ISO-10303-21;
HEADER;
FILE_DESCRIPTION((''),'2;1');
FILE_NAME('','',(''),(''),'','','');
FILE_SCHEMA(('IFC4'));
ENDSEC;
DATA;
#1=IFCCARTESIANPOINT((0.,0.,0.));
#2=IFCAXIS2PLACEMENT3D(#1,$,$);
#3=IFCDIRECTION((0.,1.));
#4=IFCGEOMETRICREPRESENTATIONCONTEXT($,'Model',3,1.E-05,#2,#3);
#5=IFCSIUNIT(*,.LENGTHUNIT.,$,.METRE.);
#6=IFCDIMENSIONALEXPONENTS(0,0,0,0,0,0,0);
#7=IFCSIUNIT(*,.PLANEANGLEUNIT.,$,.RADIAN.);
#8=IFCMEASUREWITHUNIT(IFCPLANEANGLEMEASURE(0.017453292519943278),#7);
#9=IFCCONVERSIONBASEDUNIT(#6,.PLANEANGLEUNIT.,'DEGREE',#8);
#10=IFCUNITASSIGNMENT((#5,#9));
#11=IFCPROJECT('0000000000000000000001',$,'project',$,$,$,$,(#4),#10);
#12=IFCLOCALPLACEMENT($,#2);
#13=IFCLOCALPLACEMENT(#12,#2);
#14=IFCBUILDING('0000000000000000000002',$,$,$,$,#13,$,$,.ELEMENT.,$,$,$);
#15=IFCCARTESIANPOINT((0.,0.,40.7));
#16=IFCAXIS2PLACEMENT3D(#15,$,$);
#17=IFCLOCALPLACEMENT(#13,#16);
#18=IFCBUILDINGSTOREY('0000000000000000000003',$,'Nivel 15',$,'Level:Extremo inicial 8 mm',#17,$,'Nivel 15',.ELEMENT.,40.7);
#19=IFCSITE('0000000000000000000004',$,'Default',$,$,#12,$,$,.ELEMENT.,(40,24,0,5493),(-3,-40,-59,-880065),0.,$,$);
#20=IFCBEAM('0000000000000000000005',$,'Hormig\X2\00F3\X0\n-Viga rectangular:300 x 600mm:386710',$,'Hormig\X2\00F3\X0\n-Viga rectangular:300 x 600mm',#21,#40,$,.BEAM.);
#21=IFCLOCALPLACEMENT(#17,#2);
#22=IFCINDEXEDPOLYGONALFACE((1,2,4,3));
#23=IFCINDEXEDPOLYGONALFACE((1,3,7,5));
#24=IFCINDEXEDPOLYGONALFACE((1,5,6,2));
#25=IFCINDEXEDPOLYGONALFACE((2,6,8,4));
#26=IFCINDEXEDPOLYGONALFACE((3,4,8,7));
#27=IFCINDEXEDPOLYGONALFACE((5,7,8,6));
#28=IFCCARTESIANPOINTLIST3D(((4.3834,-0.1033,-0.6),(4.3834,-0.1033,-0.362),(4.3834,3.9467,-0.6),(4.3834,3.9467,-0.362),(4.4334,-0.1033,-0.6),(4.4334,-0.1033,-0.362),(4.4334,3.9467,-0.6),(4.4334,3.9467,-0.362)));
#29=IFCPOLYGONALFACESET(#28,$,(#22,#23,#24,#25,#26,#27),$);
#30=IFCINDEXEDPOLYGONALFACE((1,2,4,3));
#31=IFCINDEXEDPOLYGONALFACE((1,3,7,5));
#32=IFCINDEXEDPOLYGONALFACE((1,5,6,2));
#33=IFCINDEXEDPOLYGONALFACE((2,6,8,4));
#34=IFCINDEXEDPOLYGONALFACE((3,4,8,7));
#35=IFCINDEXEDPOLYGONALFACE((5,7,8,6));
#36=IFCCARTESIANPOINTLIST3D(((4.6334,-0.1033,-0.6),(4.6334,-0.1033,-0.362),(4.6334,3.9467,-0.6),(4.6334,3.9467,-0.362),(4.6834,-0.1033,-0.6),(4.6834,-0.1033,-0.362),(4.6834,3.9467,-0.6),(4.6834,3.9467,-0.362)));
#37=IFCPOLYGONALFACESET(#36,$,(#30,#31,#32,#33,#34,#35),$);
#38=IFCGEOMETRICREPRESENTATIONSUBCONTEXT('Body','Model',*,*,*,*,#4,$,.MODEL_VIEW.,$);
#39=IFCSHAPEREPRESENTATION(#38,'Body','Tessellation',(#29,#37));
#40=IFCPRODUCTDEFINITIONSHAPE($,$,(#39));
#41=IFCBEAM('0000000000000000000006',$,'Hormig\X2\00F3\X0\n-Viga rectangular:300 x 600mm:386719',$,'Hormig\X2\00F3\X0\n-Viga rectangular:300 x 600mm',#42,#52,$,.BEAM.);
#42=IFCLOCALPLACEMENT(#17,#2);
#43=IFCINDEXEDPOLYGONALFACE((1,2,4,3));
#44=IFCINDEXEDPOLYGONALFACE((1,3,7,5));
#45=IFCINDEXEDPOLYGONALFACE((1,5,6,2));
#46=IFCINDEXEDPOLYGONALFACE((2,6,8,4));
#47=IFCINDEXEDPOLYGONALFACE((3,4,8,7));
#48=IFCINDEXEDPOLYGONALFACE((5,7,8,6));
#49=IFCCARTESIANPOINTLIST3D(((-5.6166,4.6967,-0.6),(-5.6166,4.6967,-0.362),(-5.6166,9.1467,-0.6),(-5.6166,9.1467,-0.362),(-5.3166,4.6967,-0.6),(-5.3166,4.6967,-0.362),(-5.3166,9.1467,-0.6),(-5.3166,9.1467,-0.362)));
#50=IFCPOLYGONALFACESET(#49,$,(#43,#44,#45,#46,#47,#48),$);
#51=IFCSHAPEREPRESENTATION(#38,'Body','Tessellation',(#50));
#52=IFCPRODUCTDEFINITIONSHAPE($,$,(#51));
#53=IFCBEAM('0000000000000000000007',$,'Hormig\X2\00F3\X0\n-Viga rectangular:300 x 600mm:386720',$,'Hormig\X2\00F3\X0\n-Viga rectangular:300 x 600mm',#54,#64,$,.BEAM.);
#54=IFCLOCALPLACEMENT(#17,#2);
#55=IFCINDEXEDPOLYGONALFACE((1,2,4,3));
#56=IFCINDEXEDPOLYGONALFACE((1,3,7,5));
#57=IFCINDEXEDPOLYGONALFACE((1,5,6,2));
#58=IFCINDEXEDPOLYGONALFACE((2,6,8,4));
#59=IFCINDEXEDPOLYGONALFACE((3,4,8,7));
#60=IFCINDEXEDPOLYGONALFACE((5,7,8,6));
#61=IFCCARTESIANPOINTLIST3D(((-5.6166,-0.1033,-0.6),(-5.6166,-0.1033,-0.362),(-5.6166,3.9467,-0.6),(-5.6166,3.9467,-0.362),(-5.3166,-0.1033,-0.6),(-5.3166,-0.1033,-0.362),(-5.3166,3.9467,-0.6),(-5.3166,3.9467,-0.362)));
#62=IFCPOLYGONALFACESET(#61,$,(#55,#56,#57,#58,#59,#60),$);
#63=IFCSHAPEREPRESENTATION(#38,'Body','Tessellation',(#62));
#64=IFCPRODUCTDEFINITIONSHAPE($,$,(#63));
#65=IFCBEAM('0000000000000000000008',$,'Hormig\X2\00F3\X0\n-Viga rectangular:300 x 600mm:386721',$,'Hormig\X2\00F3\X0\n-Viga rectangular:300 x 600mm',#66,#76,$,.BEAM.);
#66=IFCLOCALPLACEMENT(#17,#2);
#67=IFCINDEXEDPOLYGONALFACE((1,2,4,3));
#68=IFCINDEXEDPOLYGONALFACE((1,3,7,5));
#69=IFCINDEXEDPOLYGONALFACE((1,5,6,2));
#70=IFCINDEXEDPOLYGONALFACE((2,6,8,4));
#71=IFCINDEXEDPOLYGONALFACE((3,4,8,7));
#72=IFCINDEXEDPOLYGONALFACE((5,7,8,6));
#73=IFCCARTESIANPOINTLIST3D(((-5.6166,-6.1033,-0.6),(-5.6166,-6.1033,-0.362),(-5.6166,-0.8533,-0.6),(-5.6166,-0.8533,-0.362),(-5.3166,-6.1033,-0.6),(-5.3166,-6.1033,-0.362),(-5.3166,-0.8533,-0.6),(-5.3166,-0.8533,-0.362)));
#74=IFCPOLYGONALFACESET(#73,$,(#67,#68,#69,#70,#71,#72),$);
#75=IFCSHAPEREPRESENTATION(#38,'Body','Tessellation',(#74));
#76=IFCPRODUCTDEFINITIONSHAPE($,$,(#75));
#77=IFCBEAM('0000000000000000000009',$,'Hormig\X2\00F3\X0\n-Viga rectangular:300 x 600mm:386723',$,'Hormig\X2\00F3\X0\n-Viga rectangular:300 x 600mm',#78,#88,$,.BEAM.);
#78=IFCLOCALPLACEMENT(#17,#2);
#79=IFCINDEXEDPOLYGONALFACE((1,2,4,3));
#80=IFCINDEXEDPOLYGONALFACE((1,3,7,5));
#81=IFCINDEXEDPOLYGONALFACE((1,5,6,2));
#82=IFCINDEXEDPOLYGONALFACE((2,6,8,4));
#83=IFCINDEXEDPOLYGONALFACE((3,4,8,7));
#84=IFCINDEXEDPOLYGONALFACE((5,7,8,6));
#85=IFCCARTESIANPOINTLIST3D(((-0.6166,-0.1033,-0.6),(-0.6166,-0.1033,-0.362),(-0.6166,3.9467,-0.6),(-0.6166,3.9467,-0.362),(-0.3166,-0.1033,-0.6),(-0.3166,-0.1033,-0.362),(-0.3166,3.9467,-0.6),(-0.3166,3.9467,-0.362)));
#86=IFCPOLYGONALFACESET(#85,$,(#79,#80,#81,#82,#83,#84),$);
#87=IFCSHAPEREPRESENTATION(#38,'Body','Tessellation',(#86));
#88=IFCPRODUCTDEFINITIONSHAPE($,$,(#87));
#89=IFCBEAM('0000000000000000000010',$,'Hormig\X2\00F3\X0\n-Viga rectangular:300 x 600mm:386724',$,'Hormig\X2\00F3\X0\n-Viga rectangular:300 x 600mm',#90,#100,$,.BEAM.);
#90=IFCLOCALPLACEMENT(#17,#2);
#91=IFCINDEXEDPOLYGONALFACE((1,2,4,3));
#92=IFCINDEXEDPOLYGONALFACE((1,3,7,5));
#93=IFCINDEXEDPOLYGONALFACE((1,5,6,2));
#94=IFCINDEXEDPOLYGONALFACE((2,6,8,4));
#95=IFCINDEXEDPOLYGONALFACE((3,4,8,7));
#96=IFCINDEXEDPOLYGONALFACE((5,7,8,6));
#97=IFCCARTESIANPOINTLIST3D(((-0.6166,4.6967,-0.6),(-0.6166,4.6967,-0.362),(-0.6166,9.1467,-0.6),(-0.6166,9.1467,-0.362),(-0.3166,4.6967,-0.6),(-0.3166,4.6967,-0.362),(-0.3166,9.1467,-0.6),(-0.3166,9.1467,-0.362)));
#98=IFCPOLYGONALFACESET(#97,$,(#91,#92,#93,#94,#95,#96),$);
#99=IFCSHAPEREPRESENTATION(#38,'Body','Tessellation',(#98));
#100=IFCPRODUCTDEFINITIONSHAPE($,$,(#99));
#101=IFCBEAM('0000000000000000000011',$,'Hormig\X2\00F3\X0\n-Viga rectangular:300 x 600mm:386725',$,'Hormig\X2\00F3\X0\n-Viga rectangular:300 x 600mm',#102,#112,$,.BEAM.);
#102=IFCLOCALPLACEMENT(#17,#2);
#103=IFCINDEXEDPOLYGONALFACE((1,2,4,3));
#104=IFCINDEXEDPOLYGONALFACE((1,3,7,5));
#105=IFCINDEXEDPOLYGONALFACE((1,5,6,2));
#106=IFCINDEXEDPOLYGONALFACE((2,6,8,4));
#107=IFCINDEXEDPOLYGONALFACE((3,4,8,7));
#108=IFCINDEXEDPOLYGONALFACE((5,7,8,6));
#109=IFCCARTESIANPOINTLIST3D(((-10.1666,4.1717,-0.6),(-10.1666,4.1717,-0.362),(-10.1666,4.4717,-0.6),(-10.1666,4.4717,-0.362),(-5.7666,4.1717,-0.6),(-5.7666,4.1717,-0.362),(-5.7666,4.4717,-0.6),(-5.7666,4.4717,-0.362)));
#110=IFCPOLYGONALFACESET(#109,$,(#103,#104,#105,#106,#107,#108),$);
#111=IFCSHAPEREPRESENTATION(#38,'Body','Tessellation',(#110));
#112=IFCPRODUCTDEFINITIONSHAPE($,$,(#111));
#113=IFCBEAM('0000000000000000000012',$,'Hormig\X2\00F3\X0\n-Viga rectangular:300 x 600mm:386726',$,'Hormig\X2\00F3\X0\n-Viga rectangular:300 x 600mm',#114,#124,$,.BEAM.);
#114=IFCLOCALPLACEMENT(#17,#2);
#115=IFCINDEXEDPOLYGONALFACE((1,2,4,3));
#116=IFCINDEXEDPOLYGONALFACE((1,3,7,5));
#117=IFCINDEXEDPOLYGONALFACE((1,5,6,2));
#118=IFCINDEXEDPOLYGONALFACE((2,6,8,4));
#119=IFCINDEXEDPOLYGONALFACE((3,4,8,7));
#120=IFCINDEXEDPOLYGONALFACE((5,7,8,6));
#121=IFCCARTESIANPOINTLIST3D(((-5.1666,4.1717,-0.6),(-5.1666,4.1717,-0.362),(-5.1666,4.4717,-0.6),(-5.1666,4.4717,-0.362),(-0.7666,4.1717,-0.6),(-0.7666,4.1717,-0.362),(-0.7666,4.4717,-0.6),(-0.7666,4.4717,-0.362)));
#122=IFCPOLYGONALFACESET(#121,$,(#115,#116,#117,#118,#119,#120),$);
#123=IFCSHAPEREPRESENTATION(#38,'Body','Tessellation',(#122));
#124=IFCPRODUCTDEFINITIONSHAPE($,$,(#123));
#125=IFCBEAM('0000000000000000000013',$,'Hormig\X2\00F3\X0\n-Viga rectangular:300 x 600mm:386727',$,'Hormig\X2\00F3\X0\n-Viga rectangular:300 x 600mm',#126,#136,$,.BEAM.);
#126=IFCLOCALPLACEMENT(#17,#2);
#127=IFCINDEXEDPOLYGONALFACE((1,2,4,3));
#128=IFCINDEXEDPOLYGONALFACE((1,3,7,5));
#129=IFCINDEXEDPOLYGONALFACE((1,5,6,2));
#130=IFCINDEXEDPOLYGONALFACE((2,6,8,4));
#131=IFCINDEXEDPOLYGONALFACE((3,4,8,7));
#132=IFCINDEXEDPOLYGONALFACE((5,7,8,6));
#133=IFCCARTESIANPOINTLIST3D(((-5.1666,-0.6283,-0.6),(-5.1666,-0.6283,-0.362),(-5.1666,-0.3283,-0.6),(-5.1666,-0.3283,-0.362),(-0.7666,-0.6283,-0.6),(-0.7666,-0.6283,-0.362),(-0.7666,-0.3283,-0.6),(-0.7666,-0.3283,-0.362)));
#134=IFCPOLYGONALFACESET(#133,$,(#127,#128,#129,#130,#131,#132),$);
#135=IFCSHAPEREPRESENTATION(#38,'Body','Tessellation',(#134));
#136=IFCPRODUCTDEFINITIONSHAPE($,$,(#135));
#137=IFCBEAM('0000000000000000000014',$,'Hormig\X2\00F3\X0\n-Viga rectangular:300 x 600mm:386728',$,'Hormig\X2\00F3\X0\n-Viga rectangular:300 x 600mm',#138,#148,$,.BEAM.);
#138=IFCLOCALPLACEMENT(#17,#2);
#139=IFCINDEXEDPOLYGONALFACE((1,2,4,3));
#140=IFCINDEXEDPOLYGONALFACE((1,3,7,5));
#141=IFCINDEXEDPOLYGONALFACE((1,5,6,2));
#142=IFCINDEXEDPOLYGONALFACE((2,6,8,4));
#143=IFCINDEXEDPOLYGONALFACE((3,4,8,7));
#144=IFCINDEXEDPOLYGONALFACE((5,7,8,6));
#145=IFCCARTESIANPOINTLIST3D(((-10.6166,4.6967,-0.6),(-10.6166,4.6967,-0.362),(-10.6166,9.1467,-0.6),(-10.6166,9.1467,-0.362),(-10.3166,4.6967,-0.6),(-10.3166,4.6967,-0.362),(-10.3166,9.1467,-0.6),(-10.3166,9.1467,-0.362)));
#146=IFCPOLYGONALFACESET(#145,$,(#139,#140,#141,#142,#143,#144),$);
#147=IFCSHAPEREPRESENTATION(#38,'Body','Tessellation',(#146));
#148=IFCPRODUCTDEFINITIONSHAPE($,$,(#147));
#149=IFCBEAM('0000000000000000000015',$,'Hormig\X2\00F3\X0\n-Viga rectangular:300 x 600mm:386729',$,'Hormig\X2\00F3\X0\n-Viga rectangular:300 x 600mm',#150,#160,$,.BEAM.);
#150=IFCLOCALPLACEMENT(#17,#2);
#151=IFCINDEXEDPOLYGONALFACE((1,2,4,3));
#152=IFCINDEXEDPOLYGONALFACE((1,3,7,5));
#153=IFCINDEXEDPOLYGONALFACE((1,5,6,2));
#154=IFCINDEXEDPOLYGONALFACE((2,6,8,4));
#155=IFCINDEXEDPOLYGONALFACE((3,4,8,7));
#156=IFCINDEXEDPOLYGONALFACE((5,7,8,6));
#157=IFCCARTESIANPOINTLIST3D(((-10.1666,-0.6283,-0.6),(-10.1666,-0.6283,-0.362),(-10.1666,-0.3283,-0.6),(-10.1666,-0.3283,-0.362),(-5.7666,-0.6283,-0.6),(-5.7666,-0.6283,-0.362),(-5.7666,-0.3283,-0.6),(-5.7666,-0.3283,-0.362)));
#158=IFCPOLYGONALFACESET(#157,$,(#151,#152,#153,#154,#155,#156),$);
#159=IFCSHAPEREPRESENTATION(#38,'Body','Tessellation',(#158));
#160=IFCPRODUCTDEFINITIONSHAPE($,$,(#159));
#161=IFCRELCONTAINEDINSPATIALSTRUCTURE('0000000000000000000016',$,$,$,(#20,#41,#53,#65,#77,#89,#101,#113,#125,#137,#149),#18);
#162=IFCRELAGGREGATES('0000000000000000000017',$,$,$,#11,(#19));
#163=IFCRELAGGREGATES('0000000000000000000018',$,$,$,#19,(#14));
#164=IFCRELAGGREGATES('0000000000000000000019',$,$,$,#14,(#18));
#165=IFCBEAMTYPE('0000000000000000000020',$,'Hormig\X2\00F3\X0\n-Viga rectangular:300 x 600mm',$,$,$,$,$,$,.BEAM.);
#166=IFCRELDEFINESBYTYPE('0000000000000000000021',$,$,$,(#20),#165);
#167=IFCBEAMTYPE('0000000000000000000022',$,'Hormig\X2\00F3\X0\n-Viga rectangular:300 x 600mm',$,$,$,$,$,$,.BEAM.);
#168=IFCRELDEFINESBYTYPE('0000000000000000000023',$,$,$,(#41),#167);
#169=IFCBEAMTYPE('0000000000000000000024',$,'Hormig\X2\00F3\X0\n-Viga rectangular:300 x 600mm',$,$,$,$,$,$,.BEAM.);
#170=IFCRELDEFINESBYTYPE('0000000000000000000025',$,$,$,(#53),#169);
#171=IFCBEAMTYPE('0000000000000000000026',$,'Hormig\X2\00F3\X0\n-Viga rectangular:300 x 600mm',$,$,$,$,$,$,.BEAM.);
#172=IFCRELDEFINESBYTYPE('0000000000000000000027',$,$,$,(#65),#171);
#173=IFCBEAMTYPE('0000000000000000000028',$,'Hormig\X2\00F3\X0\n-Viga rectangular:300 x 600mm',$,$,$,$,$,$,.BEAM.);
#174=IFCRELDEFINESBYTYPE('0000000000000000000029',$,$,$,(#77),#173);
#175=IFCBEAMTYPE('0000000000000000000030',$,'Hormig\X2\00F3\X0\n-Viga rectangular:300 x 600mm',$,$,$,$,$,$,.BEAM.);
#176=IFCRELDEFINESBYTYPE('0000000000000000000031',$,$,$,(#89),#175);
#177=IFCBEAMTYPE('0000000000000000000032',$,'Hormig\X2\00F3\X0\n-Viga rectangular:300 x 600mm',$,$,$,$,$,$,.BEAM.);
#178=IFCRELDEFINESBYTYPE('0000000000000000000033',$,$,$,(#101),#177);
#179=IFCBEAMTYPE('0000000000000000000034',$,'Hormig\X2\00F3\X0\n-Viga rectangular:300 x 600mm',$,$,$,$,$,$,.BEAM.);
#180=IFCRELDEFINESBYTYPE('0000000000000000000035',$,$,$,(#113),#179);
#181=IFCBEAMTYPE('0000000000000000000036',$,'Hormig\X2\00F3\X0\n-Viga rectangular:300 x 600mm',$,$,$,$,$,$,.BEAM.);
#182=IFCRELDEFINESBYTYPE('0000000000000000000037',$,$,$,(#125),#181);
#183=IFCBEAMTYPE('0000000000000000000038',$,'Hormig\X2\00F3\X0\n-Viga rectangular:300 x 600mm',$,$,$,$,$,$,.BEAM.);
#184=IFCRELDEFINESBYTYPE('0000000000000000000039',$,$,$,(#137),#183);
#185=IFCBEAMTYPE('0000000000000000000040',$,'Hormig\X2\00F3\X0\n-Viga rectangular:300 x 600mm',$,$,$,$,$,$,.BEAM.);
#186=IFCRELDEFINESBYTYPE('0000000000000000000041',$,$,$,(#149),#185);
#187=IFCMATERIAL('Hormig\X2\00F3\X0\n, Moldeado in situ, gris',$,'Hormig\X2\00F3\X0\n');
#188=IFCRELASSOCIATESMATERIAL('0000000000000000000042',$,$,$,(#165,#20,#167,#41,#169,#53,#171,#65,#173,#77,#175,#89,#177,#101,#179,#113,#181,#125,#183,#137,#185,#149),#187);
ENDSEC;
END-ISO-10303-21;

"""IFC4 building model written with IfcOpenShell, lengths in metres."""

from ifc_helpers import new_model, entity, si_unit, converted_unit, direction, frame, origin, place, context, subcontext, project, spatial, indexed_curve, outline, extrude, source, transform, mapped, material, type_object, type_shapes, element, save


model = new_model("IFC4")

# Units and contexts
model_context = context("Model", 3, precision=1e-05, world=origin(), true_north=direction((0.0, 1.0)))
body_context = subcontext(model_context, "Body", "Model", "MODEL_VIEW")
ifc_project = project(units=[si_unit("LENGTHUNIT", "METRE"), converted_unit("PLANEANGLEUNIT", "DEGREE", entity("IfcPlaneAngleMeasure", 0.017453292519943278), si_unit("PLANEANGLEUNIT", "RADIAN"), dimensions=[0, 0, 0, 0, 0, 0, 0])], contexts=[model_context])

# Site, building, storey
site_placement = place(None, origin())
site = spatial("IfcSite", under=ifc_project, at=site_placement, Name="Default", CompositionType="ELEMENT", RefLatitude=(40, 24, 0, 5493), RefLongitude=(-3, -40, -59, -880065), RefElevation=0.0)
building_placement = place(site_placement, origin())
building = spatial("IfcBuilding", under=site, at=building_placement, CompositionType="ELEMENT")
storey_placement = place(building_placement, frame((0.0, 0.0, 40.7)))
storey = spatial("IfcBuildingStorey", under=building, at=storey_placement, Name="Nivel 15", ObjectType="Level:Extremo inicial 8 mm", LongName="Nivel 15", CompositionType="ELEMENT", Elevation=40.7)

# Shared definitions
ifc_material_1 = material(Name="Hormigón, Moldeado in situ, gris", Category="Hormigón")

# Beams
beam_type_1 = type_object("IfcBeamType", Name="Hormigón-Viga rectangular:300 x 600mm", PredefinedType="BEAM", material=ifc_material_1)
shared_shape_1 = source(origin(), body_context, "Body", "SweptSolid", [
    extrude(outline(indexed_curve([(-0.025, -0.119), (0.025, -0.119), (0.025, 0.119), (-0.025, 0.119), (-0.025, -0.119)], self_intersect=False)), frame((4.4084, 3.9467, 40.219), z_axis=(0.0, -1.0, 0.0), x_axis=(-1.0, 0.0, 0.0)), (0.0, 0.0, 1.0), 4.05),
    extrude(outline(indexed_curve([(-0.025, -0.119), (0.025, -0.119), (0.025, 0.119), (-0.025, 0.119), (-0.025, -0.119)], self_intersect=False)), frame((4.6584, 3.9467, 40.219), z_axis=(0.0, -1.0, 0.0), x_axis=(-1.0, 0.0, 0.0)), (0.0, 0.0, 1.0), 4.05),
])
type_shapes(beam_type_1, [shared_shape_1])
beam_1_placement = place(storey_placement, frame((0.0, 0.0, -40.7)))
element("IfcBeam", 1, at=beam_1_placement, inside=storey, type_object=beam_type_1, material=ifc_material_1, Name="Hormigón-Viga rectangular:300 x 600mm:386710", ObjectType="Hormigón-Viga rectangular:300 x 600mm", PredefinedType="BEAM", context=body_context, shape_type="MappedRepresentation", body=[
    mapped(shared_shape_1, transform((0.0, 0.0, 0.0), scale=1.0)),
])
beam_type_2 = type_object("IfcBeamType", Name="Hormigón-Viga rectangular:300 x 600mm", PredefinedType="BEAM", material=ifc_material_1)
shared_shape_2 = source(origin(), body_context, "Body", "SweptSolid", [
    extrude(outline(indexed_curve([(-0.15, -0.119), (0.15, -0.119), (0.15, 0.119), (-0.15, 0.119), (-0.15, -0.119)], self_intersect=False)), frame((-5.4666, 9.1467, 40.219), z_axis=(0.0, -1.0, 0.0), x_axis=(-1.0, 0.0, 0.0)), (0.0, 0.0, 1.0), 4.45),
])
type_shapes(beam_type_2, [shared_shape_2])
beam_2_placement = place(storey_placement, frame((0.0, 0.0, -40.7)))
element("IfcBeam", 2, at=beam_2_placement, inside=storey, type_object=beam_type_2, material=ifc_material_1, Name="Hormigón-Viga rectangular:300 x 600mm:386719", ObjectType="Hormigón-Viga rectangular:300 x 600mm", PredefinedType="BEAM", context=body_context, shape_type="MappedRepresentation", body=[
    mapped(shared_shape_2, transform((0.0, 0.0, 0.0), scale=1.0)),
])
beam_type_3 = type_object("IfcBeamType", Name="Hormigón-Viga rectangular:300 x 600mm", PredefinedType="BEAM", material=ifc_material_1)
shared_shape_3 = source(origin(), body_context, "Body", "SweptSolid", [
    extrude(outline(indexed_curve([(-0.15, -0.119), (0.15, -0.119), (0.15, 0.119), (-0.15, 0.119), (-0.15, -0.119)], self_intersect=False)), frame((-5.4666, 3.9467, 40.219), z_axis=(0.0, -1.0, 0.0), x_axis=(-1.0, 0.0, 0.0)), (0.0, 0.0, 1.0), 4.05),
])
type_shapes(beam_type_3, [shared_shape_3])
beam_3_placement = place(storey_placement, frame((0.0, 0.0, -40.7)))
element("IfcBeam", 3, at=beam_3_placement, inside=storey, type_object=beam_type_3, material=ifc_material_1, Name="Hormigón-Viga rectangular:300 x 600mm:386720", ObjectType="Hormigón-Viga rectangular:300 x 600mm", PredefinedType="BEAM", context=body_context, shape_type="MappedRepresentation", body=[
    mapped(shared_shape_3, transform((0.0, 0.0, 0.0), scale=1.0)),
])
beam_type_4 = type_object("IfcBeamType", Name="Hormigón-Viga rectangular:300 x 600mm", PredefinedType="BEAM", material=ifc_material_1)
shared_shape_4 = source(origin(), body_context, "Body", "SweptSolid", [
    extrude(outline(indexed_curve([(-0.15, -0.119), (0.15, -0.119), (0.15, 0.119), (-0.15, 0.119), (-0.15, -0.119)], self_intersect=False)), frame((-5.4666, -6.1033, 40.219), z_axis=(0.0, 1.0, 0.0), x_axis=(-1.0, 0.0, 0.0)), (0.0, 0.0, 1.0), 5.25),
])
type_shapes(beam_type_4, [shared_shape_4])
beam_4_placement = place(storey_placement, frame((0.0, 0.0, -40.7)))
element("IfcBeam", 4, at=beam_4_placement, inside=storey, type_object=beam_type_4, material=ifc_material_1, Name="Hormigón-Viga rectangular:300 x 600mm:386721", ObjectType="Hormigón-Viga rectangular:300 x 600mm", PredefinedType="BEAM", context=body_context, shape_type="MappedRepresentation", body=[
    mapped(shared_shape_4, transform((0.0, 0.0, 0.0), scale=1.0)),
])
beam_type_5 = type_object("IfcBeamType", Name="Hormigón-Viga rectangular:300 x 600mm", PredefinedType="BEAM", material=ifc_material_1)
shared_shape_5 = source(origin(), body_context, "Body", "SweptSolid", [
    extrude(outline(indexed_curve([(-0.15, -0.119), (0.15, -0.119), (0.15, 0.119), (-0.15, 0.119), (-0.15, -0.119)], self_intersect=False)), frame((-0.4666, -0.1033, 40.219), z_axis=(0.0, 1.0, 0.0), x_axis=(-1.0, 0.0, 0.0)), (0.0, 0.0, 1.0), 4.05),
])
type_shapes(beam_type_5, [shared_shape_5])
beam_5_placement = place(storey_placement, frame((0.0, 0.0, -40.7)))
element("IfcBeam", 5, at=beam_5_placement, inside=storey, type_object=beam_type_5, material=ifc_material_1, Name="Hormigón-Viga rectangular:300 x 600mm:386723", ObjectType="Hormigón-Viga rectangular:300 x 600mm", PredefinedType="BEAM", context=body_context, shape_type="MappedRepresentation", body=[
    mapped(shared_shape_5, transform((0.0, 0.0, 0.0), scale=1.0)),
])
beam_type_6 = type_object("IfcBeamType", Name="Hormigón-Viga rectangular:300 x 600mm", PredefinedType="BEAM", material=ifc_material_1)
shared_shape_6 = source(origin(), body_context, "Body", "SweptSolid", [
    extrude(outline(indexed_curve([(-0.15, -0.119), (0.15, -0.119), (0.15, 0.119), (-0.15, 0.119), (-0.15, -0.119)], self_intersect=False)), frame((-0.4666, 9.1467, 40.219), z_axis=(0.0, -1.0, 0.0), x_axis=(-1.0, 0.0, 0.0)), (0.0, 0.0, 1.0), 4.45),
])
type_shapes(beam_type_6, [shared_shape_6])
beam_6_placement = place(storey_placement, frame((0.0, 0.0, -40.7)))
element("IfcBeam", 6, at=beam_6_placement, inside=storey, type_object=beam_type_6, material=ifc_material_1, Name="Hormigón-Viga rectangular:300 x 600mm:386724", ObjectType="Hormigón-Viga rectangular:300 x 600mm", PredefinedType="BEAM", context=body_context, shape_type="MappedRepresentation", body=[
    mapped(shared_shape_6, transform((0.0, 0.0, 0.0), scale=1.0)),
])
beam_type_7 = type_object("IfcBeamType", Name="Hormigón-Viga rectangular:300 x 600mm", PredefinedType="BEAM", material=ifc_material_1)
shared_shape_7 = source(origin(), body_context, "Body", "SweptSolid", [
    extrude(outline(indexed_curve([(-0.119, -0.15), (0.119, -0.15), (0.119, 0.15), (-0.119, 0.15), (-0.119, -0.15)], self_intersect=False)), frame((-10.1666, 4.3217, 40.219), z_axis=(1.0, 0.0, 0.0), x_axis=(0.0, 0.0, -1.0)), (0.0, 0.0, 1.0), 4.4),
])
type_shapes(beam_type_7, [shared_shape_7])
beam_7_placement = place(storey_placement, frame((0.0, 0.0, -40.7)))
element("IfcBeam", 7, at=beam_7_placement, inside=storey, type_object=beam_type_7, material=ifc_material_1, Name="Hormigón-Viga rectangular:300 x 600mm:386725", ObjectType="Hormigón-Viga rectangular:300 x 600mm", PredefinedType="BEAM", context=body_context, shape_type="MappedRepresentation", body=[
    mapped(shared_shape_7, transform((0.0, 0.0, 0.0), scale=1.0)),
])
beam_type_8 = type_object("IfcBeamType", Name="Hormigón-Viga rectangular:300 x 600mm", PredefinedType="BEAM", material=ifc_material_1)
shared_shape_8 = source(origin(), body_context, "Body", "SweptSolid", [
    extrude(outline(indexed_curve([(-0.119, -0.15), (0.119, -0.15), (0.119, 0.15), (-0.119, 0.15), (-0.119, -0.15)], self_intersect=False)), frame((-5.1666, 4.3217, 40.219), z_axis=(1.0, 0.0, 0.0), x_axis=(0.0, 0.0, -1.0)), (0.0, 0.0, 1.0), 4.4),
])
type_shapes(beam_type_8, [shared_shape_8])
beam_8_placement = place(storey_placement, frame((0.0, 0.0, -40.7)))
element("IfcBeam", 8, at=beam_8_placement, inside=storey, type_object=beam_type_8, material=ifc_material_1, Name="Hormigón-Viga rectangular:300 x 600mm:386726", ObjectType="Hormigón-Viga rectangular:300 x 600mm", PredefinedType="BEAM", context=body_context, shape_type="MappedRepresentation", body=[
    mapped(shared_shape_8, transform((0.0, 0.0, 0.0), scale=1.0)),
])
beam_type_9 = type_object("IfcBeamType", Name="Hormigón-Viga rectangular:300 x 600mm", PredefinedType="BEAM", material=ifc_material_1)
shared_shape_9 = source(origin(), body_context, "Body", "SweptSolid", [
    extrude(outline(indexed_curve([(-0.119, -0.15), (0.119, -0.15), (0.119, 0.15), (-0.119, 0.15), (-0.119, -0.15)], self_intersect=False)), frame((-0.7666, -0.4783, 40.219), z_axis=(-1.0, 0.0, 0.0), x_axis=(0.0, 0.0, -1.0)), (0.0, 0.0, 1.0), 4.4),
])
type_shapes(beam_type_9, [shared_shape_9])
beam_9_placement = place(storey_placement, frame((0.0, 0.0, -40.7)))
element("IfcBeam", 9, at=beam_9_placement, inside=storey, type_object=beam_type_9, material=ifc_material_1, Name="Hormigón-Viga rectangular:300 x 600mm:386727", ObjectType="Hormigón-Viga rectangular:300 x 600mm", PredefinedType="BEAM", context=body_context, shape_type="MappedRepresentation", body=[
    mapped(shared_shape_9, transform((0.0, 0.0, 0.0), scale=1.0)),
])
beam_type_10 = type_object("IfcBeamType", Name="Hormigón-Viga rectangular:300 x 600mm", PredefinedType="BEAM", material=ifc_material_1)
shared_shape_10 = source(origin(), body_context, "Body", "SweptSolid", [
    extrude(outline(indexed_curve([(-0.15, -0.119), (0.15, -0.119), (0.15, 0.119), (-0.15, 0.119), (-0.15, -0.119)], self_intersect=False)), frame((-10.4666, 4.6967, 40.219), z_axis=(0.0, 1.0, 0.0), x_axis=(-1.0, 0.0, 0.0)), (0.0, 0.0, 1.0), 4.45),
])
type_shapes(beam_type_10, [shared_shape_10])
beam_10_placement = place(storey_placement, frame((0.0, 0.0, -40.7)))
element("IfcBeam", 10, at=beam_10_placement, inside=storey, type_object=beam_type_10, material=ifc_material_1, Name="Hormigón-Viga rectangular:300 x 600mm:386728", ObjectType="Hormigón-Viga rectangular:300 x 600mm", PredefinedType="BEAM", context=body_context, shape_type="MappedRepresentation", body=[
    mapped(shared_shape_10, transform((0.0, 0.0, 0.0), scale=1.0)),
])
beam_type_11 = type_object("IfcBeamType", Name="Hormigón-Viga rectangular:300 x 600mm", PredefinedType="BEAM", material=ifc_material_1)
shared_shape_11 = source(origin(), body_context, "Body", "SweptSolid", [
    extrude(outline(indexed_curve([(-0.119, -0.15), (0.119, -0.15), (0.119, 0.15), (-0.119, 0.15), (-0.119, -0.15)], self_intersect=False)), frame((-10.1666, -0.4783, 40.219), z_axis=(1.0, 0.0, 0.0), x_axis=(0.0, 0.0, -1.0)), (0.0, 0.0, 1.0), 4.4),
])
type_shapes(beam_type_11, [shared_shape_11])
beam_11_placement = place(storey_placement, frame((0.0, 0.0, -40.7)))
element("IfcBeam", 11, at=beam_11_placement, inside=storey, type_object=beam_type_11, material=ifc_material_1, Name="Hormigón-Viga rectangular:300 x 600mm:386729", ObjectType="Hormigón-Viga rectangular:300 x 600mm", PredefinedType="BEAM", context=body_context, shape_type="MappedRepresentation", body=[
    mapped(shared_shape_11, transform((0.0, 0.0, 0.0), scale=1.0)),
])

save(model, "model.ifc")
